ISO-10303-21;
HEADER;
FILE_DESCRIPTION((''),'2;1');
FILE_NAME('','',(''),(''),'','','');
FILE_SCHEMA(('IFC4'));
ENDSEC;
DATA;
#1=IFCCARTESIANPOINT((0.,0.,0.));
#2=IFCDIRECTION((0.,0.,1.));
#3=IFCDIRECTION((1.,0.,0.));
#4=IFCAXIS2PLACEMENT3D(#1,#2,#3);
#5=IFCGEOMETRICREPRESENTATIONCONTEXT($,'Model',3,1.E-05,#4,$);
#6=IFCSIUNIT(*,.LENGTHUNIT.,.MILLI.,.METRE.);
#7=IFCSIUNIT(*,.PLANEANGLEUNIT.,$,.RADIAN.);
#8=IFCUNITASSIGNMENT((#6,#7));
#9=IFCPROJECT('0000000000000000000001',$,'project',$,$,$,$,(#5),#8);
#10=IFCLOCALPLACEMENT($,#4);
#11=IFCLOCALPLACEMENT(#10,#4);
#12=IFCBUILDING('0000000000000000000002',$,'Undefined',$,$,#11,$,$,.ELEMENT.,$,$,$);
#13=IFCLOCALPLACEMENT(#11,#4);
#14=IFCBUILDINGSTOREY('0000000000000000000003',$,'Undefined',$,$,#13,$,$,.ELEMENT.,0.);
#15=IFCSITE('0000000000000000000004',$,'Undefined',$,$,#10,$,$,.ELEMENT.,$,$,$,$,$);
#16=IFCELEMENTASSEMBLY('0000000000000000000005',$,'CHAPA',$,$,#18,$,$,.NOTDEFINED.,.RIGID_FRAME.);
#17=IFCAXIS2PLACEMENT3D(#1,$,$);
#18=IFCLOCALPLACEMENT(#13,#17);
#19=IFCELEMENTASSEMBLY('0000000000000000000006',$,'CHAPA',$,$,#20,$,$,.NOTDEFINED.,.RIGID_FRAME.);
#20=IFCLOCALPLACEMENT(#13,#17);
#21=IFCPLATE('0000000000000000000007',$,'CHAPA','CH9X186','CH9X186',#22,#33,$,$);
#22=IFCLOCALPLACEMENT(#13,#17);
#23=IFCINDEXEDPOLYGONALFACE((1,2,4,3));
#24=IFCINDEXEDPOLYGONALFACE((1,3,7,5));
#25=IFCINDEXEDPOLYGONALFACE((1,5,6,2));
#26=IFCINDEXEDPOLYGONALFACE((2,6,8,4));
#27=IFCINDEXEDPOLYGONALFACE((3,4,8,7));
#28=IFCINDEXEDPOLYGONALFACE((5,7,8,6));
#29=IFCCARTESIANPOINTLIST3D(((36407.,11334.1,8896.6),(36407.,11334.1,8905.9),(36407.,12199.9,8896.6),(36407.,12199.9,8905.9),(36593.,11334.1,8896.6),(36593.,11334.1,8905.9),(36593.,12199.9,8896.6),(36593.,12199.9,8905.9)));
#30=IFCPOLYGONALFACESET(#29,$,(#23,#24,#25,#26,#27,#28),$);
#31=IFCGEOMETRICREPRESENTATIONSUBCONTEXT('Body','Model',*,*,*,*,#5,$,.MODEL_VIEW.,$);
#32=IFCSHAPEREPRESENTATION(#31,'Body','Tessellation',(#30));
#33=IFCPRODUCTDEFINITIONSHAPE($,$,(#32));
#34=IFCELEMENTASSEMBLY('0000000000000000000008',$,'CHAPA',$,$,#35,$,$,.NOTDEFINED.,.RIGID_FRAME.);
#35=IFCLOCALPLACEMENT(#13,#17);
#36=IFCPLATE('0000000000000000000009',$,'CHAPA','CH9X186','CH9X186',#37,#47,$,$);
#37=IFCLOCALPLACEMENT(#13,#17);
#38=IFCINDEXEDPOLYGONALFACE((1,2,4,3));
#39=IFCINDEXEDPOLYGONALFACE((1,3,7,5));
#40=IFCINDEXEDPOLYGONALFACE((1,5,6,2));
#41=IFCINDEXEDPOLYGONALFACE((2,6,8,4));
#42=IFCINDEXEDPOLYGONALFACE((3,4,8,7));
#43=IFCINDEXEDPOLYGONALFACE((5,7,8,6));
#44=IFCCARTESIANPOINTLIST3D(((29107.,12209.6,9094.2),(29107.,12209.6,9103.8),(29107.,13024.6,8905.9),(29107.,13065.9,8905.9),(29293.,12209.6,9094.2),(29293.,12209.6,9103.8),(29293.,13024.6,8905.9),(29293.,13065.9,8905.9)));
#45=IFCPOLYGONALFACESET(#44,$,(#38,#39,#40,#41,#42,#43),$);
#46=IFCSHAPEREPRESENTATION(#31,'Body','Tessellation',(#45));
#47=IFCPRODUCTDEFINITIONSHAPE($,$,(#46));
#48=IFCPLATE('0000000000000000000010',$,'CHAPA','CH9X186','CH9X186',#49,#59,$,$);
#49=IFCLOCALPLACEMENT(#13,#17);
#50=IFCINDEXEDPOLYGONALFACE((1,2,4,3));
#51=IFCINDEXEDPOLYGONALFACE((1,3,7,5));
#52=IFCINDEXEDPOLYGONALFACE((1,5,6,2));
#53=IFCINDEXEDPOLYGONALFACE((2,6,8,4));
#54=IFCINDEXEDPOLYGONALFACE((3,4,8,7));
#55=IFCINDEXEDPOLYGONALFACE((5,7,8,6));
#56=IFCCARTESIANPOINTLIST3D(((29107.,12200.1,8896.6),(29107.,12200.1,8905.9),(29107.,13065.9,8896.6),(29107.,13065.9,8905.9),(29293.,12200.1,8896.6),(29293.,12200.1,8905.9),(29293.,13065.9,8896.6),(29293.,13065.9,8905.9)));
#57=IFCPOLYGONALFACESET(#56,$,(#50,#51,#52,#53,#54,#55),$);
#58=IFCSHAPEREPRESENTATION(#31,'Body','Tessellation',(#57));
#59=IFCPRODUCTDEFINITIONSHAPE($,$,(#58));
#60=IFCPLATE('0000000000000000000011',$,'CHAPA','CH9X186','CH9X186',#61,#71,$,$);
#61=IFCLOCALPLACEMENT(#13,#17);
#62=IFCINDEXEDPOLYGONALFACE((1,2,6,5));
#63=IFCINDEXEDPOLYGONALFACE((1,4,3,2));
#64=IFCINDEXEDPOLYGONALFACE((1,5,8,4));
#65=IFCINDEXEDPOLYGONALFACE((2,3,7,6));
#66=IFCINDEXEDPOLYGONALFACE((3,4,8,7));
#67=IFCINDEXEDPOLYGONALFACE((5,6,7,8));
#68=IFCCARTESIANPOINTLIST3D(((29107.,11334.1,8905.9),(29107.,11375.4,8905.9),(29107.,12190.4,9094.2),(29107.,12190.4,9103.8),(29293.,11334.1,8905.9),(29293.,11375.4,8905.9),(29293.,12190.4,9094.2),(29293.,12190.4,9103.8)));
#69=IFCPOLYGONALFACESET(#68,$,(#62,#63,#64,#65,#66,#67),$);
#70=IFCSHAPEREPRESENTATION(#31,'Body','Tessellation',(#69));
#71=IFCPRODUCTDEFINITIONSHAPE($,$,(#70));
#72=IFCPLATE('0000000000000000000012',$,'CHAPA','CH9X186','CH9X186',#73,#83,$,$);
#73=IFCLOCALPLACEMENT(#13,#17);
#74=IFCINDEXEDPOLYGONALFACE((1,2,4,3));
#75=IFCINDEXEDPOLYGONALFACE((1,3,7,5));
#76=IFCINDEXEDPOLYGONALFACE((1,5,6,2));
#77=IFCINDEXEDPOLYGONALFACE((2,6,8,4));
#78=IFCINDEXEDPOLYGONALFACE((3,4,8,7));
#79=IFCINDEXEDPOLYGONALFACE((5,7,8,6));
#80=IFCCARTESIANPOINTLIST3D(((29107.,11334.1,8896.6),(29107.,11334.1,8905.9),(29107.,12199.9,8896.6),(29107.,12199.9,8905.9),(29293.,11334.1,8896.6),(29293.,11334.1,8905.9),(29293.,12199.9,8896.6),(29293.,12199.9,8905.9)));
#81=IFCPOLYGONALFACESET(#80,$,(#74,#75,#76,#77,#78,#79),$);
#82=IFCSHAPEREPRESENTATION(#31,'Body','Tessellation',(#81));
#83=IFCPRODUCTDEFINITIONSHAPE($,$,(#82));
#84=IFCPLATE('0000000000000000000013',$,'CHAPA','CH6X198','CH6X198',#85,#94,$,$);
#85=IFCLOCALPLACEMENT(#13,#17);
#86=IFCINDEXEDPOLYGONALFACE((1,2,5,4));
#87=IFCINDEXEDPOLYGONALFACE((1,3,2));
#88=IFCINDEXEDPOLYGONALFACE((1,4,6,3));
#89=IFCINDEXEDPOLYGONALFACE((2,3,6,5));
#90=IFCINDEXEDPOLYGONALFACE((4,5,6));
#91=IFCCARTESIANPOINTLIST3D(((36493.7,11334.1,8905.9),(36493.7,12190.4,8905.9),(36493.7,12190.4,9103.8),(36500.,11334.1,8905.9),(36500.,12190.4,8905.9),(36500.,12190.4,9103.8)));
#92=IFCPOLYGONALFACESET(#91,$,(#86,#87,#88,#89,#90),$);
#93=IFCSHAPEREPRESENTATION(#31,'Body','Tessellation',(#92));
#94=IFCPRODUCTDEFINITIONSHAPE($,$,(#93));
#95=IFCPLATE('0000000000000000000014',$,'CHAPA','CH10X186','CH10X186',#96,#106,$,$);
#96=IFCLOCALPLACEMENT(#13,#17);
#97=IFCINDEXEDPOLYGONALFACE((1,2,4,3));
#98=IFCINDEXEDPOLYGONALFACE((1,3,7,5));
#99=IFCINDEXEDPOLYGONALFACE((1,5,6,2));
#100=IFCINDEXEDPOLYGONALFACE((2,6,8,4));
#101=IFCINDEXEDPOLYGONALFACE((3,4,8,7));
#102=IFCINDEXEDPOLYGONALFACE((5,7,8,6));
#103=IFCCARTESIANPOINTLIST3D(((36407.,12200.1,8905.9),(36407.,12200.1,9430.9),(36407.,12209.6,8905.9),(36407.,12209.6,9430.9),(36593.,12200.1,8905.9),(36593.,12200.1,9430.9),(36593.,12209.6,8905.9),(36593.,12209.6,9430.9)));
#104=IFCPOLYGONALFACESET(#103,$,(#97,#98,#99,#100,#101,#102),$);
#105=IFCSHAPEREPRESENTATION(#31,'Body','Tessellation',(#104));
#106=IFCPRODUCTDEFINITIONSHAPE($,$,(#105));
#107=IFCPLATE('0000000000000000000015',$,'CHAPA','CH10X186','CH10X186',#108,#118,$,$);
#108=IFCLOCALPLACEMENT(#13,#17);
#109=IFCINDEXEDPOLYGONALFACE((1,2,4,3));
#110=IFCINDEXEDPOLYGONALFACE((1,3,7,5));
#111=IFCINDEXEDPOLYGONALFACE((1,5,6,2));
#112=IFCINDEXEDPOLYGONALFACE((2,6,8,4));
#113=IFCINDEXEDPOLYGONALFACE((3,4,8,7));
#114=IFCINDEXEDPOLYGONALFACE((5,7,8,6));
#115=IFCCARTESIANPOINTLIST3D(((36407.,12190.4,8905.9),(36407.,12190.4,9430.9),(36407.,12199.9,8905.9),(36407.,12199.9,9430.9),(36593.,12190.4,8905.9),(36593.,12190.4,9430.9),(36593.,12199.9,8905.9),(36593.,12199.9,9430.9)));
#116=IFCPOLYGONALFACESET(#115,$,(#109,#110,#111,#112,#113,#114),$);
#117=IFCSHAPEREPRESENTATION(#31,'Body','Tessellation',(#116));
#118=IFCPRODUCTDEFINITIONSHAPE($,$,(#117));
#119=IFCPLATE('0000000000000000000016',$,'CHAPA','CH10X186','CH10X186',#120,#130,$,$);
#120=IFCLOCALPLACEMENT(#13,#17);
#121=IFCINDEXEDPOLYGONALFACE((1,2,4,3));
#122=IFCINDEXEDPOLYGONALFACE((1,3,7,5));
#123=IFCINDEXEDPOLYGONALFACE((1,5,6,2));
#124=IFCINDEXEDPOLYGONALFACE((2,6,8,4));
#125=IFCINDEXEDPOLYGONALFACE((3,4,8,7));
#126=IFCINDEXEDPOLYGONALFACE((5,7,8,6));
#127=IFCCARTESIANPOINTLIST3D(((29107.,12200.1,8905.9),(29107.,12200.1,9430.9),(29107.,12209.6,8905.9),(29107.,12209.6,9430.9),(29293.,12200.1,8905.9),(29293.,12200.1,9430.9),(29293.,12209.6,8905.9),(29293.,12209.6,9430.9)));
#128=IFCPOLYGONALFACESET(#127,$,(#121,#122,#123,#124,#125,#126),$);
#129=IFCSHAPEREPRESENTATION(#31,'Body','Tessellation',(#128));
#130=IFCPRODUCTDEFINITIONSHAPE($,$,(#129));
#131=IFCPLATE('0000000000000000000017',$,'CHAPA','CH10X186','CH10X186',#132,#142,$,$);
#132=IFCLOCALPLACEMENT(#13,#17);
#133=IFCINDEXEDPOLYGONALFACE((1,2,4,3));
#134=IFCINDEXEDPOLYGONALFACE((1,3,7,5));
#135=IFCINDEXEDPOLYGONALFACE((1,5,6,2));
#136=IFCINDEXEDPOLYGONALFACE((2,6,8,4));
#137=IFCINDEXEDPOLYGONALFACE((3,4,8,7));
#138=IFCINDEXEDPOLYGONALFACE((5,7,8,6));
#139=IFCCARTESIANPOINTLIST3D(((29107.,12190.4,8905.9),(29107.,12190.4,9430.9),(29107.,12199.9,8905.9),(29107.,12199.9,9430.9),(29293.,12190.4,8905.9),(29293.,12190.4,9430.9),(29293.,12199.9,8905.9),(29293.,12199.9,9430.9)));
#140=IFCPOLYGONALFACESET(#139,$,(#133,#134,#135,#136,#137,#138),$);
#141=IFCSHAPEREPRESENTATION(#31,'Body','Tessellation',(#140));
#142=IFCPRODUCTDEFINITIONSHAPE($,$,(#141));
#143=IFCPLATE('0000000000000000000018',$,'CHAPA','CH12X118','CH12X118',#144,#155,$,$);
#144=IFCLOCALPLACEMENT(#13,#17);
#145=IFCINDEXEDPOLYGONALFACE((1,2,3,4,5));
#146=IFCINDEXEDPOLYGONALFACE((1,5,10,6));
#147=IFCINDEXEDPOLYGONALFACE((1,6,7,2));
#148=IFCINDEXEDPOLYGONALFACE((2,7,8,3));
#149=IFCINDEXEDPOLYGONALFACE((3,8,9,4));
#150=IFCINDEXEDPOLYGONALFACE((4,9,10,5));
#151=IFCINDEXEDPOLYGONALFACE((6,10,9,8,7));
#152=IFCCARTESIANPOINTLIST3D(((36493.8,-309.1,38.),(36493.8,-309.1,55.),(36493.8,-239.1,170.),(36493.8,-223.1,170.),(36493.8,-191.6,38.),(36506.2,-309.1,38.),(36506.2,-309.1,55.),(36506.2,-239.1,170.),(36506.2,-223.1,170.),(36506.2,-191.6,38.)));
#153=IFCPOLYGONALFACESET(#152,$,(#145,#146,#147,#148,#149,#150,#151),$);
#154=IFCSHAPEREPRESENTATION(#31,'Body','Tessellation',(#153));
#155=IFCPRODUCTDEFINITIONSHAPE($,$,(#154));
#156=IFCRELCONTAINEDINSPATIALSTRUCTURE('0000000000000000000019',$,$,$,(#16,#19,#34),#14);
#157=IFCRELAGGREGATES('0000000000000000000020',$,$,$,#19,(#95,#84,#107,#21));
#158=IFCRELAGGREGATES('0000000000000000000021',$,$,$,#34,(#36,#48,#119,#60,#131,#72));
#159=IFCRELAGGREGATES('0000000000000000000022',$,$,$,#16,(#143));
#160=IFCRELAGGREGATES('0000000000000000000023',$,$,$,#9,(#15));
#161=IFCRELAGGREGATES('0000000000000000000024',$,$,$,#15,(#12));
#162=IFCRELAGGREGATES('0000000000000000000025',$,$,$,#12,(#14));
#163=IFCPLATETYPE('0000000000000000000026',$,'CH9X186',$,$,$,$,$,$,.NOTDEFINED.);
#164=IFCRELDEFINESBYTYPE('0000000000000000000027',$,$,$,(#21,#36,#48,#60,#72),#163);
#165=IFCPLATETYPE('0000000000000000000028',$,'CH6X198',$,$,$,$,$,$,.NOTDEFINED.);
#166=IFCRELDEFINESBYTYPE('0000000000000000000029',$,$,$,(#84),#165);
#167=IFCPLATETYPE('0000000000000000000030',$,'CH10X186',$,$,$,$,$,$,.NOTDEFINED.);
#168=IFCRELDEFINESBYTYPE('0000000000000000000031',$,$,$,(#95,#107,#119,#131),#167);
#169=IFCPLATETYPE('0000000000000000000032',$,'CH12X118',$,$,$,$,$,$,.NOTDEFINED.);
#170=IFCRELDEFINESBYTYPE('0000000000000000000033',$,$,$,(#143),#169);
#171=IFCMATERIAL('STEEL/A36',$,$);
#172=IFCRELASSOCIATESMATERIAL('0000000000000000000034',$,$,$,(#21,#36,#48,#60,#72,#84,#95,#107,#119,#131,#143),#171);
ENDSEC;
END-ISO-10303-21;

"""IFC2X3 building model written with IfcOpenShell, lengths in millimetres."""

from ifc_helpers import new_model, si_unit, frame, origin_with_axes, place, context, subcontext, project, spatial, polyline, outline, extrude, clip, halfspace, material, type_object, element, aggregate, save


model = new_model("IFC2X3")

# Units and contexts
model_context = context("Model", 3, precision=1e-05, world=origin_with_axes())
body_context = subcontext(model_context, "Body", "Model", "MODEL_VIEW")
ifc_project = project(units=[si_unit("LENGTHUNIT", "METRE", prefix="MILLI"), si_unit("PLANEANGLEUNIT", "RADIAN")], contexts=[model_context])

# Site, building, storey
site_placement = place(None, origin_with_axes())
site = spatial("IfcSite", under=ifc_project, at=site_placement, Name="Undefined", CompositionType="ELEMENT")
building_placement = place(site_placement, origin_with_axes())
building = spatial("IfcBuilding", under=site, at=building_placement, Name="Undefined", CompositionType="ELEMENT")
storey_placement = place(building_placement, origin_with_axes())
storey = spatial("IfcBuildingStorey", under=building, at=storey_placement, Name="Undefined", CompositionType="ELEMENT", Elevation=0.0)

# Element assembly
assembly_1_placement = place(storey_placement, origin_with_axes())
assembly_1 = element("IfcElementAssembly", 1, at=assembly_1_placement, inside=storey, Name="CHAPA", AssemblyPlace="NOTDEFINED", PredefinedType="RIGID_FRAME")

# Shared definitions
ifc_material_1 = material(Name="STEEL/A36")

# Element assemblies, plates
assembly_2_placement = place(storey_placement, origin_with_axes())
assembly_2 = element("IfcElementAssembly", 2, at=assembly_2_placement, inside=storey, Name="CHAPA", AssemblyPlace="NOTDEFINED", PredefinedType="RIGID_FRAME")
plate_type_1 = type_object("IfcPlateType", Name="CH9X186", PredefinedType="NOTDEFINED")
plate_1_placement = place(assembly_2_placement, frame((36593.0, 12199.9, 8901.3), z_axis=(0.0, 0.0, 1.0), x_axis=(-1.0, 0.0, 0.0)))
plate_1 = element("IfcPlate", 3, at=plate_1_placement, type_object=plate_type_1, material=ifc_material_1, Name="CHAPA", Description="CH9X186", ObjectType="CH9X186", context=body_context, shape_type="SweptSolid", body=[
    extrude(outline(polyline([(0.0, 0.0), (186.0, 0.0), (186.0, 865.8), (0.0, 865.8), (0.0, 0.0)])), frame((0.0, 0.0, -4.7), z_axis=(0.0, 0.0, 1.0), x_axis=(1.0, 0.0, 0.0)), (0.0, 0.0, 1.0), 9.3),
])
assembly_3_placement = place(storey_placement, origin_with_axes())
assembly_3 = element("IfcElementAssembly", 4, at=assembly_3_placement, inside=storey, Name="CHAPA", AssemblyPlace="NOTDEFINED", PredefinedType="RIGID_FRAME")
plate_2_placement = place(assembly_3_placement, frame((29293.0, 12208.6, 9099.3), z_axis=(0.0, -0.225125, -0.97433), x_axis=(-1.0, 0.0, 0.0)))
plate_2 = element("IfcPlate", 5, at=plate_2_placement, type_object=plate_type_1, material=ifc_material_1, Name="CHAPA", Description="CH9X186", ObjectType="CH9X186", context=body_context, shape_type="Clipping", body=[
    clip(clip(extrude(outline(polyline([(0.0, 0.0), (186.0, 0.0), (186.0, 878.9), (0.0, 878.9), (0.0, 0.0)])), frame((0.0, 0.0, -4.7), z_axis=(0.0, 0.0, 1.0), x_axis=(1.0, 0.0, 0.0)), (0.0, 0.0, 1.0), 9.3), halfspace(frame((186.0, -500.0, 314.0), z_axis=(0.0, 0.225128, 0.974329), x_axis=(-1.0, 0.0, 0.0)), False)), halfspace(frame((0.0, 2.1, 4.7), z_axis=(0.0, -0.97433, 0.225125), x_axis=(1.0, 0.0, 0.0)), False)),
])
plate_3_placement = place(assembly_3_placement, frame((29293.0, 12200.1, 8901.3), z_axis=(0.0, 0.0, -1.0), x_axis=(-1.0, 0.0, 0.0)))
plate_3 = element("IfcPlate", 6, at=plate_3_placement, type_object=plate_type_1, material=ifc_material_1, Name="CHAPA", Description="CH9X186", ObjectType="CH9X186", context=body_context, shape_type="SweptSolid", body=[
    extrude(outline(polyline([(0.0, 0.0), (186.0, 0.0), (186.0, 865.8), (0.0, 865.8), (0.0, 0.0)])), frame((0.0, 0.0, -4.7), z_axis=(0.0, 0.0, 1.0), x_axis=(1.0, 0.0, 0.0)), (0.0, 0.0, 1.0), 9.3),
])
plate_4_placement = place(assembly_3_placement, frame((29293.0, 12191.4, 9099.3), z_axis=(0.0, -0.225125, 0.97433), x_axis=(-1.0, 0.0, 0.0)))
plate_4 = element("IfcPlate", 7, at=plate_4_placement, type_object=plate_type_1, material=ifc_material_1, Name="CHAPA", Description="CH9X186", ObjectType="CH9X186", context=body_context, shape_type="Clipping", body=[
    clip(clip(extrude(outline(polyline([(0.0, 0.0), (186.0, 0.0), (186.0, 878.9), (0.0, 878.9), (0.0, 0.0)])), frame((0.0, 0.0, -4.7), z_axis=(0.0, 0.0, 1.0), x_axis=(1.0, 0.0, 0.0)), (0.0, 0.0, 1.0), 9.3), halfspace(frame((186.0, -500.0, -314.0), z_axis=(0.0, 0.225128, -0.974329), x_axis=(0.0, 0.974329, 0.225128)), False)), halfspace(frame((0.0, 2.1, -4.6), z_axis=(0.0, -0.97433, -0.225125), x_axis=(0.0, -0.225125, 0.97433)), False)),
])
plate_5_placement = place(assembly_3_placement, frame((29293.0, 12199.9, 8901.3), z_axis=(0.0, 0.0, 1.0), x_axis=(-1.0, 0.0, 0.0)))
plate_5 = element("IfcPlate", 8, at=plate_5_placement, type_object=plate_type_1, material=ifc_material_1, Name="CHAPA", Description="CH9X186", ObjectType="CH9X186", context=body_context, shape_type="SweptSolid", body=[
    extrude(outline(polyline([(0.0, 0.0), (186.0, 0.0), (186.0, 865.8), (0.0, 865.8), (0.0, 0.0)])), frame((0.0, 0.0, -4.7), z_axis=(0.0, 0.0, 1.0), x_axis=(1.0, 0.0, 0.0)), (0.0, 0.0, 1.0), 9.3),
])

# Plates
plate_type_2 = type_object("IfcPlateType", Name="CH6X198", PredefinedType="NOTDEFINED")
plate_6_placement = place(assembly_2_placement, frame((36496.8, 11334.1, 8905.9), z_axis=(1.0, 0.0, 0.0), x_axis=(0.0, 1.0, 0.0)))
plate_6 = element("IfcPlate", 9, at=plate_6_placement, type_object=plate_type_2, material=ifc_material_1, Name="CHAPA", Description="CH6X198", ObjectType="CH6X198", context=body_context, shape_type="SweptSolid", body=[
    extrude(outline(polyline([(0.0, 0.0), (856.3, 0.0), (856.3, 197.9), (0.0, 0.0)])), frame((0.0, 0.0, -3.1), z_axis=(0.0, 0.0, 1.0), x_axis=(1.0, 0.0, 0.0)), (0.0, 0.0, 1.0), 6.3),
])
plate_type_3 = type_object("IfcPlateType", Name="CH10X186", PredefinedType="NOTDEFINED")
plate_7_placement = place(assembly_2_placement, frame((36593.0, 12204.8, 9430.9), z_axis=(0.0, -1.0, 0.0), x_axis=(-1.0, 0.0, 0.0)))
plate_7 = element("IfcPlate", 10, at=plate_7_placement, type_object=plate_type_3, material=ifc_material_1, Name="CHAPA", Description="CH10X186", ObjectType="CH10X186", context=body_context, shape_type="SweptSolid", body=[
    extrude(outline(polyline([(0.0, 0.0), (186.0, 0.0), (186.0, 525.0), (0.0, 525.0), (0.0, 0.0)])), frame((0.0, 0.0, -4.8), z_axis=(0.0, 0.0, 1.0), x_axis=(1.0, 0.0, 0.0)), (0.0, 0.0, 1.0), 9.5),
])
plate_8_placement = place(assembly_2_placement, frame((36593.0, 12195.2, 9430.9), z_axis=(0.0, -1.0, 0.0), x_axis=(-1.0, 0.0, 0.0)))
plate_8 = element("IfcPlate", 11, at=plate_8_placement, type_object=plate_type_3, material=ifc_material_1, Name="CHAPA", Description="CH10X186", ObjectType="CH10X186", context=body_context, shape_type="SweptSolid", body=[
    extrude(outline(polyline([(0.0, 0.0), (186.0, 0.0), (186.0, 525.0), (0.0, 525.0), (0.0, 0.0)])), frame((0.0, 0.0, -4.8), z_axis=(0.0, 0.0, 1.0), x_axis=(1.0, 0.0, 0.0)), (0.0, 0.0, 1.0), 9.5),
])
aggregate(assembly_2, [plate_7, plate_6, plate_8, plate_1])
plate_9_placement = place(assembly_3_placement, frame((29293.0, 12204.8, 9430.9), z_axis=(0.0, -1.0, 0.0), x_axis=(-1.0, 0.0, 0.0)))
plate_9 = element("IfcPlate", 12, at=plate_9_placement, type_object=plate_type_3, material=ifc_material_1, Name="CHAPA", Description="CH10X186", ObjectType="CH10X186", context=body_context, shape_type="SweptSolid", body=[
    extrude(outline(polyline([(0.0, 0.0), (186.0, 0.0), (186.0, 525.0), (0.0, 525.0), (0.0, 0.0)])), frame((0.0, 0.0, -4.8), z_axis=(0.0, 0.0, 1.0), x_axis=(1.0, 0.0, 0.0)), (0.0, 0.0, 1.0), 9.5),
])
plate_10_placement = place(assembly_3_placement, frame((29293.0, 12195.2, 9430.9), z_axis=(0.0, -1.0, 0.0), x_axis=(-1.0, 0.0, 0.0)))
plate_10 = element("IfcPlate", 13, at=plate_10_placement, type_object=plate_type_3, material=ifc_material_1, Name="CHAPA", Description="CH10X186", ObjectType="CH10X186", context=body_context, shape_type="SweptSolid", body=[
    extrude(outline(polyline([(0.0, 0.0), (186.0, 0.0), (186.0, 525.0), (0.0, 525.0), (0.0, 0.0)])), frame((0.0, 0.0, -4.8), z_axis=(0.0, 0.0, 1.0), x_axis=(1.0, 0.0, 0.0)), (0.0, 0.0, 1.0), 9.5),
])
aggregate(assembly_3, [plate_2, plate_3, plate_9, plate_4, plate_10, plate_5])
plate_type_4 = type_object("IfcPlateType", Name="CH12X118", PredefinedType="NOTDEFINED")
plate_11_placement = place(assembly_1_placement, frame((36500.0, -309.1, 38.0), z_axis=(1.0, 0.0, 0.0), x_axis=(0.0, 1.0, 0.0)))
plate_11 = element("IfcPlate", 14, at=plate_11_placement, type_object=plate_type_4, material=ifc_material_1, Name="CHAPA", Description="CH12X118", ObjectType="CH12X118", context=body_context, shape_type="SweptSolid", body=[
    extrude(outline(polyline([(0.0, 0.0), (117.5, 0.0), (85.9, 132.0), (70.0, 132.0), (0.0, 17.0), (0.0, 0.0)])), frame((0.0, 0.0, -6.2), z_axis=(0.0, 0.0, 1.0), x_axis=(1.0, 0.0, 0.0)), (0.0, 0.0, 1.0), 12.5),
])

aggregate(assembly_1, [plate_11])

save(model, "model.ifc")
